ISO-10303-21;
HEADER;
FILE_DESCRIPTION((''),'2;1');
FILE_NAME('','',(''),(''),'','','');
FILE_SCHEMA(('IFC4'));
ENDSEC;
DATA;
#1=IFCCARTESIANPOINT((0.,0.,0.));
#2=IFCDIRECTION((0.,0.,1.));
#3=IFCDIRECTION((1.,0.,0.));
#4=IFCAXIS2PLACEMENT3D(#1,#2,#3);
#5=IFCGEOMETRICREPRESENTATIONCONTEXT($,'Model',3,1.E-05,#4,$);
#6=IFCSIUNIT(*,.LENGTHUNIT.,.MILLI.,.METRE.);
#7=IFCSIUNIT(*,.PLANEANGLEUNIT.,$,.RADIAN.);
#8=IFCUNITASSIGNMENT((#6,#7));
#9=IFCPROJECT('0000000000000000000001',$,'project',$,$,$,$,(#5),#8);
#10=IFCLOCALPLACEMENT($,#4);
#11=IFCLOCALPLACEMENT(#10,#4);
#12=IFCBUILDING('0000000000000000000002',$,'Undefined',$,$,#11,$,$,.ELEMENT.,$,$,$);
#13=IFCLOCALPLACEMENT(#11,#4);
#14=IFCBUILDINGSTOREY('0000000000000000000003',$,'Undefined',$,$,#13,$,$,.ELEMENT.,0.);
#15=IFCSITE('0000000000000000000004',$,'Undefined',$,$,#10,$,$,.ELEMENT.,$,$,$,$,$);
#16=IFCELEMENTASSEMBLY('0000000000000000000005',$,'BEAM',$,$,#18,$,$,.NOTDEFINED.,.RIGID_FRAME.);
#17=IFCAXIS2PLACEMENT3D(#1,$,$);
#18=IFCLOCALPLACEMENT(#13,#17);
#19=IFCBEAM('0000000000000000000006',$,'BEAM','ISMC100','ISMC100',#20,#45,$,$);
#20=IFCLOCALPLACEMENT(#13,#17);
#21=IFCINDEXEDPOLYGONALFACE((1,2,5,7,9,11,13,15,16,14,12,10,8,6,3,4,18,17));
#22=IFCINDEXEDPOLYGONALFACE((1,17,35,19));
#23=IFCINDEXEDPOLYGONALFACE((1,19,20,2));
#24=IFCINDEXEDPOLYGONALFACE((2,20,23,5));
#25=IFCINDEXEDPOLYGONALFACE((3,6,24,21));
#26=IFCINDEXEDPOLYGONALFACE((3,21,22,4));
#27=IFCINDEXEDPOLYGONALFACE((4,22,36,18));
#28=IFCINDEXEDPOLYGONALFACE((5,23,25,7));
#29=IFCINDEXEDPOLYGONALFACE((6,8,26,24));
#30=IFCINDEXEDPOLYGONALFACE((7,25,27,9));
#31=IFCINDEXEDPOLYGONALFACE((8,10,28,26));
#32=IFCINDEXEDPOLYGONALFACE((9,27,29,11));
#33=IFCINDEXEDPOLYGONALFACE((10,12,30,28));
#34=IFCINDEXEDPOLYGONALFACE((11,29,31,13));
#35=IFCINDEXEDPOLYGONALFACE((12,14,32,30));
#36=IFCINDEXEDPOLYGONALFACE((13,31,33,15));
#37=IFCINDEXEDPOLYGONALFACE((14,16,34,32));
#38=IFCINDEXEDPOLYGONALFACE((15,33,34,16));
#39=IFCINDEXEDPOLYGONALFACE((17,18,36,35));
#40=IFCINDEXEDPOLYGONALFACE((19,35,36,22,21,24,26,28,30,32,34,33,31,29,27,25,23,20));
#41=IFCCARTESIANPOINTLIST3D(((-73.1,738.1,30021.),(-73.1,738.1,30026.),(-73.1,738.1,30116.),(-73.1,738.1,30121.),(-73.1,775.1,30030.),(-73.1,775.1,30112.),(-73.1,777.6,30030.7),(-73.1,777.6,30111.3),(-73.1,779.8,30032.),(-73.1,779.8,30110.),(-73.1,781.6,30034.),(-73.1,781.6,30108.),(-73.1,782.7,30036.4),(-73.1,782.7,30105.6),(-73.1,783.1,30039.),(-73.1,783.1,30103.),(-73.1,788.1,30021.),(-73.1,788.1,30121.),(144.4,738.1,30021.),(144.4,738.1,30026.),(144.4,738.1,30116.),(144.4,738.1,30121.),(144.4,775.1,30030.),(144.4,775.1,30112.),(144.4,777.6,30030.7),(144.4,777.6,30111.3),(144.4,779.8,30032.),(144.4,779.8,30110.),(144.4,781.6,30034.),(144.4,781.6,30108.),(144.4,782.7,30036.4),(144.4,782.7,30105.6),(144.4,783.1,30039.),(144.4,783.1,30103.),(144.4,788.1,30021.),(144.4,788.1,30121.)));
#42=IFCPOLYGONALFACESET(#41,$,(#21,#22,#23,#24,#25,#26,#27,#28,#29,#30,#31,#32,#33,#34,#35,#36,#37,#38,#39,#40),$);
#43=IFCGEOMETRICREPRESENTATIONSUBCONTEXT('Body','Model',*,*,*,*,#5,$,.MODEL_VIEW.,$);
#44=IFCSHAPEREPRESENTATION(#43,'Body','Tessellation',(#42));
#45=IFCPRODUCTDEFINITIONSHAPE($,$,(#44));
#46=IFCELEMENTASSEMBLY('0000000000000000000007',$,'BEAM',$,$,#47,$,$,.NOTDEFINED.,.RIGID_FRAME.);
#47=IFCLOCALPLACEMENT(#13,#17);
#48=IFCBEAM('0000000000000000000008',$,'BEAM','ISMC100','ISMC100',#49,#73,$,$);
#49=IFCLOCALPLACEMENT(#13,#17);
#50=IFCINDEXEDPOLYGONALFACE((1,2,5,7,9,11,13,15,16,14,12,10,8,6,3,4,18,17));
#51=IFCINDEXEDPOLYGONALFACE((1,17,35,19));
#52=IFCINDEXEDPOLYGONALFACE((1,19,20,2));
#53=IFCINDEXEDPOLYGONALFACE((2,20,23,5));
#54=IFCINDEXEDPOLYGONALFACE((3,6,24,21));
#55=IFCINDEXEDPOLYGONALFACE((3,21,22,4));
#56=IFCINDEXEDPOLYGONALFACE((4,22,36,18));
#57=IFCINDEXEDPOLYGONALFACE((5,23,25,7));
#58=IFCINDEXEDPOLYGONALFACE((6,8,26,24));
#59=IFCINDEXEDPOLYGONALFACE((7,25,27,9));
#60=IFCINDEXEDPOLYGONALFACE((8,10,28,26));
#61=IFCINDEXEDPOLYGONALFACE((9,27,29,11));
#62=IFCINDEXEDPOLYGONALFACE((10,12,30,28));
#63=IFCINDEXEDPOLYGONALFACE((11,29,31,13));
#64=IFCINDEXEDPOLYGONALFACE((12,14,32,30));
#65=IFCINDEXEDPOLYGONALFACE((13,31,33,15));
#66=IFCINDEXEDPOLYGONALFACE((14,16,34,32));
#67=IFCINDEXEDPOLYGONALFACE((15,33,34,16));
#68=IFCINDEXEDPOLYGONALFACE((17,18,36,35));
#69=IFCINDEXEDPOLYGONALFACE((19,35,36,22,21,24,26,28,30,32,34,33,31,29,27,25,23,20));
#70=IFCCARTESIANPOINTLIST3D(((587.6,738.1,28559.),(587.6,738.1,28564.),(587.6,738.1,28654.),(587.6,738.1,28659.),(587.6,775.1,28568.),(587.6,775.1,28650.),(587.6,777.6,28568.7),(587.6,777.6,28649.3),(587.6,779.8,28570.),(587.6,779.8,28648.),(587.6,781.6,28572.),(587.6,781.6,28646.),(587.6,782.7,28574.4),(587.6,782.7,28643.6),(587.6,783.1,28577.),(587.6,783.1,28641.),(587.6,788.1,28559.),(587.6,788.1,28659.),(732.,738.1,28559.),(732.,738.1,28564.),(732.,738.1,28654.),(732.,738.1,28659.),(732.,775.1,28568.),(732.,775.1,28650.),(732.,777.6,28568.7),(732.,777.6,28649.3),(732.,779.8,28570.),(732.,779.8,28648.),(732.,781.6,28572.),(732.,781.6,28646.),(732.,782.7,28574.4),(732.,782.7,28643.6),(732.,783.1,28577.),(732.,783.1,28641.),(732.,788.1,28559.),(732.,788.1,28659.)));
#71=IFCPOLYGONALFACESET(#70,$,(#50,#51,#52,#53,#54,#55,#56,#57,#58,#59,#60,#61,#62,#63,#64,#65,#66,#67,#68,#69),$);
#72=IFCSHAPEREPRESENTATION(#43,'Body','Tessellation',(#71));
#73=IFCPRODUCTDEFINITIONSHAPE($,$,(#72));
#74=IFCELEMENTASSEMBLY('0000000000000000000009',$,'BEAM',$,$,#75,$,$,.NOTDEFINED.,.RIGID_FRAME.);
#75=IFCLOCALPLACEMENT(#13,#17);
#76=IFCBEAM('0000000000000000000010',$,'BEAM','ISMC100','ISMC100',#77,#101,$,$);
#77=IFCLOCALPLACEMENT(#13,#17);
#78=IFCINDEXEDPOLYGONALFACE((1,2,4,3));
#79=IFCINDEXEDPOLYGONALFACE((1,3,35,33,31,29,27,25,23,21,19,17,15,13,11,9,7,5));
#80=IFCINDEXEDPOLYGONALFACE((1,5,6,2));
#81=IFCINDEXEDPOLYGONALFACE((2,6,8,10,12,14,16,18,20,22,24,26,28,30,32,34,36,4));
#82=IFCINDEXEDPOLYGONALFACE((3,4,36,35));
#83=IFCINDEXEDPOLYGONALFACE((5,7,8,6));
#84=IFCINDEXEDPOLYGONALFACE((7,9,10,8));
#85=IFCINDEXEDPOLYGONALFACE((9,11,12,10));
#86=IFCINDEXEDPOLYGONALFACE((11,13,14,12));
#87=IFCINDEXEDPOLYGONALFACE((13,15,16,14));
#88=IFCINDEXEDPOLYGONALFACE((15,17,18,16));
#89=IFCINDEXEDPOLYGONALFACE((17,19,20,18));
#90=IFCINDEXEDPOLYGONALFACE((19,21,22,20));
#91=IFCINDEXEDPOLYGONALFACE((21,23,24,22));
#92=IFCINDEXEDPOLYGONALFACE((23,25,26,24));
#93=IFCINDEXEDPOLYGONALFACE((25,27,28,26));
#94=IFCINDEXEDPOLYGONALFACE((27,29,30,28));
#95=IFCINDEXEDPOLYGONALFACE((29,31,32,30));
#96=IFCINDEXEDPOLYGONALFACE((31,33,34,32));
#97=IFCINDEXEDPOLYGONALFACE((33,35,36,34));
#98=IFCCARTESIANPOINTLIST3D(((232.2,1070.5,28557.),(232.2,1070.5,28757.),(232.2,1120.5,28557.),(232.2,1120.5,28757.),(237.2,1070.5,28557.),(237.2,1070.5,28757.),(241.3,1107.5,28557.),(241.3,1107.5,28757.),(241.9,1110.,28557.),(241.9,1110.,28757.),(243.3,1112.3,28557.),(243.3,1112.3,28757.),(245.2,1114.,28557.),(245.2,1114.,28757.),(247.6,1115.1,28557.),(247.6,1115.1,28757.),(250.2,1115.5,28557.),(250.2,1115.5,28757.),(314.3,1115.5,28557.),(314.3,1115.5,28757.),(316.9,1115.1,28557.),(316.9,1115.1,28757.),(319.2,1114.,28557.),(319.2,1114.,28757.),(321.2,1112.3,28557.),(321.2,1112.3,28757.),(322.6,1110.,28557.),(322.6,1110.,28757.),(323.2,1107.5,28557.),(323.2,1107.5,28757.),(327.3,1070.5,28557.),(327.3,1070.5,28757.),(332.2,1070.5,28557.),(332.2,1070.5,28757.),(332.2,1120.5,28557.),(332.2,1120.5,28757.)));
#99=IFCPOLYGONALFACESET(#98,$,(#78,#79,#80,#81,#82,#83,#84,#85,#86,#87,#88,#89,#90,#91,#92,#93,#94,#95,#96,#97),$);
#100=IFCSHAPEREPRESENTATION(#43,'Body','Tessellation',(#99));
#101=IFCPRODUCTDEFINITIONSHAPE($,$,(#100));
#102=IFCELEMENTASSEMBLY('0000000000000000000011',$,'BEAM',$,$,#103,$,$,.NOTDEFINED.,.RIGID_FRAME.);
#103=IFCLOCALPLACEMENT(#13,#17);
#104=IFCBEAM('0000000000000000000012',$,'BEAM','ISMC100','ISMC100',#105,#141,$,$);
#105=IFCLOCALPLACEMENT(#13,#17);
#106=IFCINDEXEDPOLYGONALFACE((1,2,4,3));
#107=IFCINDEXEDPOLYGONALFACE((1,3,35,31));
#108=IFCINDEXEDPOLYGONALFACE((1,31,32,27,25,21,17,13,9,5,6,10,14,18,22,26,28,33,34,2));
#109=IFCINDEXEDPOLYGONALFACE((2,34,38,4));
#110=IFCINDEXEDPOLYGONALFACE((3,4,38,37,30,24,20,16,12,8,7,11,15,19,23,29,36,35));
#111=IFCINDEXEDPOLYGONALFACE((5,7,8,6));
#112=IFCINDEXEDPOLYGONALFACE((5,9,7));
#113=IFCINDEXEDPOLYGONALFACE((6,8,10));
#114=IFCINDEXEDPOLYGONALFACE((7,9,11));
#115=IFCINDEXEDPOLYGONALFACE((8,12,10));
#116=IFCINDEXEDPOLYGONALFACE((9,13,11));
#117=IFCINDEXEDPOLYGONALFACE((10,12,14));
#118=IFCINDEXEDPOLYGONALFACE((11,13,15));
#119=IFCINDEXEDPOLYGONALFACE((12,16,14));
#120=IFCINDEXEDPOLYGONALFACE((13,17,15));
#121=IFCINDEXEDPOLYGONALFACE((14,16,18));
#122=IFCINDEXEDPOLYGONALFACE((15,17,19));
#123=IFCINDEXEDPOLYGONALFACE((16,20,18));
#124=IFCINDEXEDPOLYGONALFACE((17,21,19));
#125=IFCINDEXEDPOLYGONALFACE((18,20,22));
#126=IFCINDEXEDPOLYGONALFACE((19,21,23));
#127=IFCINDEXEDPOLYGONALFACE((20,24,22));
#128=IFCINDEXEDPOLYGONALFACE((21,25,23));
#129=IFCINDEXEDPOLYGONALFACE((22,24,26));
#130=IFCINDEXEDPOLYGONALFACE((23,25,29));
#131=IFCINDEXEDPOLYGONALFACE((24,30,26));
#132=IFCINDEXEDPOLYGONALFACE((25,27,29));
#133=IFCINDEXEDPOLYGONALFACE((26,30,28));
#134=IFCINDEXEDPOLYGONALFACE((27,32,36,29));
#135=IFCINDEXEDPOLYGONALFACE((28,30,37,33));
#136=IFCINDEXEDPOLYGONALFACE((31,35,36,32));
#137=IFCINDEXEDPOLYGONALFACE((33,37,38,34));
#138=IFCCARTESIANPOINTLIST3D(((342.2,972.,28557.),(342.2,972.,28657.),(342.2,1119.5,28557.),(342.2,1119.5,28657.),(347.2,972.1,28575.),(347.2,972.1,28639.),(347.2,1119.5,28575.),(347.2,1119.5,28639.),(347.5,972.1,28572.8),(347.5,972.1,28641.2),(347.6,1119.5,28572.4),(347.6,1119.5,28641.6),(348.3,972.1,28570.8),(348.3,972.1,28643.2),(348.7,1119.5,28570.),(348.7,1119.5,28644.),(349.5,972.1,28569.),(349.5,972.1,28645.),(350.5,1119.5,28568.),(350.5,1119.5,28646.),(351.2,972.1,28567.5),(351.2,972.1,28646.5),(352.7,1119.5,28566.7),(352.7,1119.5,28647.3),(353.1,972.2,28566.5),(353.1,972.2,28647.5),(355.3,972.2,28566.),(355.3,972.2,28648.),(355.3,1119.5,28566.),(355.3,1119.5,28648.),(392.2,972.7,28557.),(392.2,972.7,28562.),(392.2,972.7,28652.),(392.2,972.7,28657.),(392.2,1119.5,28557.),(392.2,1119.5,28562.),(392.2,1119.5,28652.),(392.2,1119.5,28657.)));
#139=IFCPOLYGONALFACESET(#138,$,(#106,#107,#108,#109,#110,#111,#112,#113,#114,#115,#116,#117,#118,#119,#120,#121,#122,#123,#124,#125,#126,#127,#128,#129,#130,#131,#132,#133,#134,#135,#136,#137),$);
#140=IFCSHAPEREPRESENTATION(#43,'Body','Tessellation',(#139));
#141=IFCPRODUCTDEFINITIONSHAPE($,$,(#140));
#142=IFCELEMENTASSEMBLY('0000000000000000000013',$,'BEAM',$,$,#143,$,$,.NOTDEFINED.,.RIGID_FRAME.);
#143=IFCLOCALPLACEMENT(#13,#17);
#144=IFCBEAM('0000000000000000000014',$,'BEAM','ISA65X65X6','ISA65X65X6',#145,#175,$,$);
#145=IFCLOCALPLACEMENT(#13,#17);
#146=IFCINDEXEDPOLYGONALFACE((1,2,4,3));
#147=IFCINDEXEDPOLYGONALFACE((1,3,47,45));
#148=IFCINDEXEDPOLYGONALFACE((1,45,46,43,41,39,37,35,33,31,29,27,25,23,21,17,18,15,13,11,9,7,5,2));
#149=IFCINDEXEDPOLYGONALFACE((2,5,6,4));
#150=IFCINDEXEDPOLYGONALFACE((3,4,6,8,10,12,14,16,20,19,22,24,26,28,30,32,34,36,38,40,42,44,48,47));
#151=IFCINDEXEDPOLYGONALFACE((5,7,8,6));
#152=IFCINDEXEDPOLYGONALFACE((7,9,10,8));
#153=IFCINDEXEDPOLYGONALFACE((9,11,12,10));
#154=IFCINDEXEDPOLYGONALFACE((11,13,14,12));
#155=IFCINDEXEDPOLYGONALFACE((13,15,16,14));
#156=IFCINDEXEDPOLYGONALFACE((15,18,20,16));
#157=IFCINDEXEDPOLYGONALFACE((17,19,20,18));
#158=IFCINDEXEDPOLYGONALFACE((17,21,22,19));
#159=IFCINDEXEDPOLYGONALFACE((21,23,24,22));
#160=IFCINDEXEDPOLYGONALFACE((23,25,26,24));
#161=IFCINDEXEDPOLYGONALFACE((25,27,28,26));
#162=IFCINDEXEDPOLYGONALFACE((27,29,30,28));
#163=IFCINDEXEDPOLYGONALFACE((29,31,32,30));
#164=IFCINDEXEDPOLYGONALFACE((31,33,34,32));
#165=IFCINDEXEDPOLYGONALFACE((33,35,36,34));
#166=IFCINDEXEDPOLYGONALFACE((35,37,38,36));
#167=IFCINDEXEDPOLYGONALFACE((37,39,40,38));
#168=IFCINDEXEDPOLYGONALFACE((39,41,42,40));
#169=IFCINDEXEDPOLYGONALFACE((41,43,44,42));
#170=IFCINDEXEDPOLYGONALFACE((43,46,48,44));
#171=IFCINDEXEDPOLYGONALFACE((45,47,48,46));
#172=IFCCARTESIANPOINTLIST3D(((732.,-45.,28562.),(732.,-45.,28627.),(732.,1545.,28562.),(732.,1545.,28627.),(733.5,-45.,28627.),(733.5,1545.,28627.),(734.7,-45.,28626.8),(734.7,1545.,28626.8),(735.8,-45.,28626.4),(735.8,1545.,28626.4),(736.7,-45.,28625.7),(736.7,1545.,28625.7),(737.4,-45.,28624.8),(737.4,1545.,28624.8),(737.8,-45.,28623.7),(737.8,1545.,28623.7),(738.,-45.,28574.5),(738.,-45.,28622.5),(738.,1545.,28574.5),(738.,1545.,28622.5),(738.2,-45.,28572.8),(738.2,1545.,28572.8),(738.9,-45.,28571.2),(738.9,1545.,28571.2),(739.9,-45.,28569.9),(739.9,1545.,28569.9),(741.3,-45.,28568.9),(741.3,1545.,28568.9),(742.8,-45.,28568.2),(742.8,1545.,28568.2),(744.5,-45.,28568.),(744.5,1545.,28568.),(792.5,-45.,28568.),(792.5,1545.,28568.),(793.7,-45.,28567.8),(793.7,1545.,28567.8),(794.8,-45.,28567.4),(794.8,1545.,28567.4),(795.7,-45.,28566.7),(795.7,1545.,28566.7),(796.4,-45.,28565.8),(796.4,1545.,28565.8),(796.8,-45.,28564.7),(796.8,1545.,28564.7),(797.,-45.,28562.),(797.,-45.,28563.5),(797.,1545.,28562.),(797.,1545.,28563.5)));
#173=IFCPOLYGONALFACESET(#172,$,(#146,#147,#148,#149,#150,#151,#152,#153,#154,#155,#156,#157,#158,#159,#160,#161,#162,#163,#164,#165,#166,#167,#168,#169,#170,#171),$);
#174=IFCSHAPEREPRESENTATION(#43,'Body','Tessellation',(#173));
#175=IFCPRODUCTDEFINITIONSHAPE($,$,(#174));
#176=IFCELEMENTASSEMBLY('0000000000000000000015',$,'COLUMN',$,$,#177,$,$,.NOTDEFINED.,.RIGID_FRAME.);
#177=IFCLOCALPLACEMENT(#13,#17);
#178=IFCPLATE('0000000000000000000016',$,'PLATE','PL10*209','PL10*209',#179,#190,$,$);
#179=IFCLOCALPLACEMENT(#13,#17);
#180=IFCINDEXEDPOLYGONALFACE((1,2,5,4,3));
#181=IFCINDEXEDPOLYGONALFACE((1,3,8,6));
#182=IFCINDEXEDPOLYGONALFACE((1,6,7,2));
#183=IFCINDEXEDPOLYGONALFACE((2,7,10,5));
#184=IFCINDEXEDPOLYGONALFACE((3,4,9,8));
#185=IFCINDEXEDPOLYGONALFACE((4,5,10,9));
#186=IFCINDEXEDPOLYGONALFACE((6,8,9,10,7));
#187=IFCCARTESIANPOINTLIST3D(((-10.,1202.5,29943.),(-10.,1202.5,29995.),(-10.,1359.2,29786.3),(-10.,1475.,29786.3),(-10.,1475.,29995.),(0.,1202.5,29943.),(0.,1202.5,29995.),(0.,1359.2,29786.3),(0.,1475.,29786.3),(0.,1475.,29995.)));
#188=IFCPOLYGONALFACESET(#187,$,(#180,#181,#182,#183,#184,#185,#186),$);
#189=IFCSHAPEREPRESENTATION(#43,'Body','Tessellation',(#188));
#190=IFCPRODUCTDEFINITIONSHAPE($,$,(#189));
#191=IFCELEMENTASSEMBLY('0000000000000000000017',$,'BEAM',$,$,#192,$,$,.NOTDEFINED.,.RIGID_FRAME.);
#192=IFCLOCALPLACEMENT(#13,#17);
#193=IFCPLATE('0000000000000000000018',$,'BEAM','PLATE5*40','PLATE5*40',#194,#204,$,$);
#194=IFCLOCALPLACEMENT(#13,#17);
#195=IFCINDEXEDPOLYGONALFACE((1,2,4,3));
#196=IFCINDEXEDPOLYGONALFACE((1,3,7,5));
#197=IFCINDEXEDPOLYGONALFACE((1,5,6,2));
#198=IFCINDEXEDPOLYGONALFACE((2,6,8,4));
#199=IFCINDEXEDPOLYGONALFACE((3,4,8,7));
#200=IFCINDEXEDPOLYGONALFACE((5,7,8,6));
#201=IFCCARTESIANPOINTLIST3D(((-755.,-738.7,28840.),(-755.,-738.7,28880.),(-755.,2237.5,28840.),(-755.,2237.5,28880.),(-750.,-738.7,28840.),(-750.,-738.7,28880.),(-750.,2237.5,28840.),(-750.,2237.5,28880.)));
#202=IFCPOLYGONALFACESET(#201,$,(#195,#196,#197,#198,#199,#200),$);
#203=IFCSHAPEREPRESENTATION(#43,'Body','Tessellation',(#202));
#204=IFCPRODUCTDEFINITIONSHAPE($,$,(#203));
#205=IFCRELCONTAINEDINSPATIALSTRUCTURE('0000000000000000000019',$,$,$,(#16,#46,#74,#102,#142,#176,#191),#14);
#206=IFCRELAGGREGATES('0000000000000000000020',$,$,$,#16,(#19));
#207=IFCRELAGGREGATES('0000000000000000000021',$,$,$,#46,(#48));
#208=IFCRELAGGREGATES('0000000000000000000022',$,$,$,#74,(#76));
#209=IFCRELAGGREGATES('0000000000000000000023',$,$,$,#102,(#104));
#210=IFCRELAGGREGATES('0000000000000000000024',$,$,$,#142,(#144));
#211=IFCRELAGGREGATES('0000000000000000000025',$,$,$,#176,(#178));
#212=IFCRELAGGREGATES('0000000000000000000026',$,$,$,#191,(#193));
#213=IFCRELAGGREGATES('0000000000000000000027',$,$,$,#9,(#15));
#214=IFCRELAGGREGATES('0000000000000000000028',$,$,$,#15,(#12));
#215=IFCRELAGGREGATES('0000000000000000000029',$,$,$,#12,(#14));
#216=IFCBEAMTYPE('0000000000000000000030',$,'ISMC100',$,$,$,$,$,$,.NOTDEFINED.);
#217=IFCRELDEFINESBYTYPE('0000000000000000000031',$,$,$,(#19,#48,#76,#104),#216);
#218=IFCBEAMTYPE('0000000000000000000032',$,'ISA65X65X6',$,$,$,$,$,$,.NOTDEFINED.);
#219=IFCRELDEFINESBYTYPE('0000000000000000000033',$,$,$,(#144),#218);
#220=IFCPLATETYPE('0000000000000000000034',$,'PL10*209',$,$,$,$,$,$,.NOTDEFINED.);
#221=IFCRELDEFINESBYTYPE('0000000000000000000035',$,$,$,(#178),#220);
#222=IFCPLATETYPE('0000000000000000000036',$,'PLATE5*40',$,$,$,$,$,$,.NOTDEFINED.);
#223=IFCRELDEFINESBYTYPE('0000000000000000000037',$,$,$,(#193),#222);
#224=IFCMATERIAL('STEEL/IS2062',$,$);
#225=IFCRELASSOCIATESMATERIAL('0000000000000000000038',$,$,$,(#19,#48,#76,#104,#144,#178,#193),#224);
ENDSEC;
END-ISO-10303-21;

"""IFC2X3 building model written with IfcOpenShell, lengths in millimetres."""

from ifc_helpers import new_model, si_unit, frame, origin_with_axes, origin_2d_with_axis, place, context, subcontext, project, spatial, polyline, l_section, u_section, outline, extrude, clip, halfspace, material, type_object, element, aggregate, save


model = new_model("IFC2X3")

# Units and contexts
model_context = context("Model", 3, precision=1e-05, world=origin_with_axes())
body_context = subcontext(model_context, "Body", "Model", "MODEL_VIEW")
ifc_project = project(units=[si_unit("LENGTHUNIT", "METRE", prefix="MILLI"), si_unit("PLANEANGLEUNIT", "RADIAN")], contexts=[model_context])

# Site, building, storey
site_placement = place(None, origin_with_axes())
site = spatial("IfcSite", under=ifc_project, at=site_placement, Name="Undefined", CompositionType="ELEMENT")
building_placement = place(site_placement, origin_with_axes())
building = spatial("IfcBuilding", under=site, at=building_placement, Name="Undefined", CompositionType="ELEMENT")
storey_placement = place(building_placement, origin_with_axes())
storey = spatial("IfcBuildingStorey", under=building, at=storey_placement, Name="Undefined", CompositionType="ELEMENT", Elevation=0.0)

# Shared definitions
ifc_material = material(Name="STEEL/IS2062")

# Element assemblies, beams
beam_type_1 = type_object("IfcBeamType", Name="ISMC100", PredefinedType="NOTDEFINED")
assembly_1_placement = place(storey_placement, origin_with_axes())
assembly_1 = element("IfcElementAssembly", 1, at=assembly_1_placement, inside=storey, Name="BEAM", AssemblyPlace="NOTDEFINED", PredefinedType="RIGID_FRAME")
beam_1_placement = place(assembly_1_placement, frame((144.4, 763.1, 30071.0), z_axis=(0.0, 0.0, -1.0), x_axis=(-1.0, 0.0, 0.0)))
beam_1 = element("IfcBeam", 2, at=beam_1_placement, type_object=beam_type_1, material=ifc_material, Name="BEAM", Description="ISMC100", ObjectType="ISMC100", context=body_context, shape_type="SweptSolid", body=[
    extrude(u_section(Depth=100.0, FlangeWidth=50.0, WebThickness=5.0, FlangeThickness=7.7, FilletRadius=9.0, FlangeSlope=0.10956, at=origin_2d_with_axis()), frame((217.6, 0.0, 0.0), z_axis=(-1.0, 0.0, 0.0), x_axis=(0.0, -1.0, 0.0)), (0.0, 0.0, 1.0), 217.6),
])
aggregate(assembly_1, [beam_1])
assembly_2_placement = place(storey_placement, origin_with_axes())
assembly_2 = element("IfcElementAssembly", 3, at=assembly_2_placement, inside=storey, Name="BEAM", AssemblyPlace="NOTDEFINED", PredefinedType="RIGID_FRAME")
beam_2_placement = place(assembly_2_placement, frame((732.0, 763.1, 28609.0), z_axis=(0.0, 0.0, -1.0), x_axis=(-1.0, 0.0, 0.0)))
beam_2 = element("IfcBeam", 4, at=beam_2_placement, type_object=beam_type_1, material=ifc_material, Name="BEAM", Description="ISMC100", ObjectType="ISMC100", context=body_context, shape_type="SweptSolid", body=[
    extrude(u_section(Depth=100.0, FlangeWidth=50.0, WebThickness=5.0, FlangeThickness=7.7, FilletRadius=9.0, FlangeSlope=0.10956, at=origin_2d_with_axis()), frame((144.4, 0.0, 0.0), z_axis=(-1.0, 0.0, 0.0), x_axis=(0.0, -1.0, 0.0)), (0.0, 0.0, 1.0), 144.4),
])
aggregate(assembly_2, [beam_2])
assembly_3_placement = place(storey_placement, origin_with_axes())
assembly_3 = element("IfcElementAssembly", 5, at=assembly_3_placement, inside=storey, Name="BEAM", AssemblyPlace="NOTDEFINED", PredefinedType="RIGID_FRAME")
beam_3_placement = place(assembly_3_placement, frame((282.2, 1095.5, 28757.0), z_axis=(1.0, 0.0, 0.0), x_axis=(0.0, 0.0, -1.0)))
beam_3 = element("IfcBeam", 6, at=beam_3_placement, type_object=beam_type_1, material=ifc_material, Name="BEAM", Description="ISMC100", ObjectType="ISMC100", context=body_context, shape_type="SweptSolid", body=[
    extrude(u_section(Depth=100.0, FlangeWidth=50.0, WebThickness=5.0, FlangeThickness=7.7, FilletRadius=9.0, FlangeSlope=0.10956, at=origin_2d_with_axis()), frame((200.0, 0.0, 0.0), z_axis=(-1.0, 0.0, 0.0), x_axis=(0.0, -1.0, 0.0)), (0.0, 0.0, 1.0), 200.0),
])
aggregate(assembly_3, [beam_3])
assembly_4_placement = place(storey_placement, origin_with_axes())
assembly_4 = element("IfcElementAssembly", 7, at=assembly_4_placement, inside=storey, Name="BEAM", AssemblyPlace="NOTDEFINED", PredefinedType="RIGID_FRAME")
beam_4_placement = place(assembly_4_placement, frame((367.2, 1119.5, 28607.0), z_axis=(0.0, 0.0, -1.0), x_axis=(0.0, -1.0, 0.0)))
beam_4 = element("IfcBeam", 8, at=beam_4_placement, type_object=beam_type_1, material=ifc_material, Name="BEAM", Description="ISMC100", ObjectType="ISMC100", context=body_context, shape_type="Clipping", body=[
    clip(extrude(u_section(Depth=100.0, FlangeWidth=50.0, WebThickness=5.0, FlangeThickness=7.7, FilletRadius=9.0, FlangeSlope=0.10956, at=origin_2d_with_axis()), frame((147.5, 0.0, 0.0), z_axis=(-1.0, 0.0, 0.0), x_axis=(0.0, -1.0, 0.0)), (0.0, 0.0, 1.0), 147.5), halfspace(frame((147.5, 25.0, -50.0), z_axis=(0.999902, -0.013997, 0.0), x_axis=(-0.013997, -0.999902, 0.0)), False)),
])
aggregate(assembly_4, [beam_4])
beam_type_2 = type_object("IfcBeamType", Name="ISA65X65X6", PredefinedType="NOTDEFINED")
assembly_5_placement = place(storey_placement, origin_with_axes())
assembly_5 = element("IfcElementAssembly", 9, at=assembly_5_placement, inside=storey, Name="BEAM", AssemblyPlace="NOTDEFINED", PredefinedType="RIGID_FRAME")
beam_5_placement = place(assembly_5_placement, frame((764.5, 1545.0, 28594.5), z_axis=(1.0, 0.0, 0.0), x_axis=(0.0, -1.0, 0.0)))
beam_5 = element("IfcBeam", 10, at=beam_5_placement, type_object=beam_type_2, material=ifc_material, Name="BEAM", Description="ISA65X65X6", ObjectType="ISA65X65X6", context=body_context, shape_type="SweptSolid", body=[
    extrude(l_section(Depth=65.0, Width=65.0, Thickness=6.0, FilletRadius=6.5, EdgeRadius=4.5, at=origin_2d_with_axis()), frame((1590.0, 0.0, 0.0), z_axis=(-1.0, 0.0, 0.0), x_axis=(0.0, -1.0, 0.0)), (0.0, 0.0, 1.0), 1590.0),
])
aggregate(assembly_5, [beam_5])

# Element assemblies, plates
assembly_6_placement = place(storey_placement, origin_with_axes())
assembly_6 = element("IfcElementAssembly", 11, at=assembly_6_placement, inside=storey, Name="COLUMN", AssemblyPlace="NOTDEFINED", PredefinedType="RIGID_FRAME")
plate_type_1 = type_object("IfcPlateType", Name="PL10*209", PredefinedType="NOTDEFINED")
plate_1_placement = place(assembly_6_placement, frame((-5.0, 1475.0, 29786.3), z_axis=(1.0, 0.0, 0.0), x_axis=(0.0, 0.0, 1.0)))
plate_1 = element("IfcPlate", 12, at=plate_1_placement, type_object=plate_type_1, material=ifc_material, Name="PLATE", Description="PL10*209", ObjectType="PL10*209", context=body_context, shape_type="SweptSolid", body=[
    extrude(outline(polyline([(0.0, 0.0), (208.7, 0.0), (208.7, 272.5), (156.7, 272.5), (0.0, 115.8), (0.0, 0.0)])), frame((0.0, 0.0, -5.0), z_axis=(0.0, 0.0, 1.0), x_axis=(1.0, 0.0, 0.0)), (0.0, 0.0, 1.0), 10.0),
])
aggregate(assembly_6, [plate_1])
assembly_7_placement = place(storey_placement, origin_with_axes())
assembly_7 = element("IfcElementAssembly", 13, at=assembly_7_placement, inside=storey, Name="BEAM", AssemblyPlace="NOTDEFINED", PredefinedType="RIGID_FRAME")
plate_type_2 = type_object("IfcPlateType", Name="PLATE5*40", PredefinedType="NOTDEFINED")
plate_2_placement = place(assembly_7_placement, frame((-752.5, 2237.5, 28860.0), z_axis=(-1.0, 0.0, 0.0), x_axis=(0.0, -1.0, 0.0)))
plate_2 = element("IfcPlate", 14, at=plate_2_placement, type_object=plate_type_2, material=ifc_material, Name="BEAM", Description="PLATE5*40", ObjectType="PLATE5*40", context=body_context, shape_type="SweptSolid", body=[
    extrude(outline(polyline([(2976.2, -20.0), (0.0, -20.0), (0.0, 20.0), (2976.2, 20.0), (2976.2, -20.0)])), frame((0.0, 0.0, -2.5), z_axis=(0.0, 0.0, 1.0), x_axis=(1.0, 0.0, 0.0)), (0.0, 0.0, 1.0), 5.0),
])
aggregate(assembly_7, [plate_2])

save(model, "model.ifc")
